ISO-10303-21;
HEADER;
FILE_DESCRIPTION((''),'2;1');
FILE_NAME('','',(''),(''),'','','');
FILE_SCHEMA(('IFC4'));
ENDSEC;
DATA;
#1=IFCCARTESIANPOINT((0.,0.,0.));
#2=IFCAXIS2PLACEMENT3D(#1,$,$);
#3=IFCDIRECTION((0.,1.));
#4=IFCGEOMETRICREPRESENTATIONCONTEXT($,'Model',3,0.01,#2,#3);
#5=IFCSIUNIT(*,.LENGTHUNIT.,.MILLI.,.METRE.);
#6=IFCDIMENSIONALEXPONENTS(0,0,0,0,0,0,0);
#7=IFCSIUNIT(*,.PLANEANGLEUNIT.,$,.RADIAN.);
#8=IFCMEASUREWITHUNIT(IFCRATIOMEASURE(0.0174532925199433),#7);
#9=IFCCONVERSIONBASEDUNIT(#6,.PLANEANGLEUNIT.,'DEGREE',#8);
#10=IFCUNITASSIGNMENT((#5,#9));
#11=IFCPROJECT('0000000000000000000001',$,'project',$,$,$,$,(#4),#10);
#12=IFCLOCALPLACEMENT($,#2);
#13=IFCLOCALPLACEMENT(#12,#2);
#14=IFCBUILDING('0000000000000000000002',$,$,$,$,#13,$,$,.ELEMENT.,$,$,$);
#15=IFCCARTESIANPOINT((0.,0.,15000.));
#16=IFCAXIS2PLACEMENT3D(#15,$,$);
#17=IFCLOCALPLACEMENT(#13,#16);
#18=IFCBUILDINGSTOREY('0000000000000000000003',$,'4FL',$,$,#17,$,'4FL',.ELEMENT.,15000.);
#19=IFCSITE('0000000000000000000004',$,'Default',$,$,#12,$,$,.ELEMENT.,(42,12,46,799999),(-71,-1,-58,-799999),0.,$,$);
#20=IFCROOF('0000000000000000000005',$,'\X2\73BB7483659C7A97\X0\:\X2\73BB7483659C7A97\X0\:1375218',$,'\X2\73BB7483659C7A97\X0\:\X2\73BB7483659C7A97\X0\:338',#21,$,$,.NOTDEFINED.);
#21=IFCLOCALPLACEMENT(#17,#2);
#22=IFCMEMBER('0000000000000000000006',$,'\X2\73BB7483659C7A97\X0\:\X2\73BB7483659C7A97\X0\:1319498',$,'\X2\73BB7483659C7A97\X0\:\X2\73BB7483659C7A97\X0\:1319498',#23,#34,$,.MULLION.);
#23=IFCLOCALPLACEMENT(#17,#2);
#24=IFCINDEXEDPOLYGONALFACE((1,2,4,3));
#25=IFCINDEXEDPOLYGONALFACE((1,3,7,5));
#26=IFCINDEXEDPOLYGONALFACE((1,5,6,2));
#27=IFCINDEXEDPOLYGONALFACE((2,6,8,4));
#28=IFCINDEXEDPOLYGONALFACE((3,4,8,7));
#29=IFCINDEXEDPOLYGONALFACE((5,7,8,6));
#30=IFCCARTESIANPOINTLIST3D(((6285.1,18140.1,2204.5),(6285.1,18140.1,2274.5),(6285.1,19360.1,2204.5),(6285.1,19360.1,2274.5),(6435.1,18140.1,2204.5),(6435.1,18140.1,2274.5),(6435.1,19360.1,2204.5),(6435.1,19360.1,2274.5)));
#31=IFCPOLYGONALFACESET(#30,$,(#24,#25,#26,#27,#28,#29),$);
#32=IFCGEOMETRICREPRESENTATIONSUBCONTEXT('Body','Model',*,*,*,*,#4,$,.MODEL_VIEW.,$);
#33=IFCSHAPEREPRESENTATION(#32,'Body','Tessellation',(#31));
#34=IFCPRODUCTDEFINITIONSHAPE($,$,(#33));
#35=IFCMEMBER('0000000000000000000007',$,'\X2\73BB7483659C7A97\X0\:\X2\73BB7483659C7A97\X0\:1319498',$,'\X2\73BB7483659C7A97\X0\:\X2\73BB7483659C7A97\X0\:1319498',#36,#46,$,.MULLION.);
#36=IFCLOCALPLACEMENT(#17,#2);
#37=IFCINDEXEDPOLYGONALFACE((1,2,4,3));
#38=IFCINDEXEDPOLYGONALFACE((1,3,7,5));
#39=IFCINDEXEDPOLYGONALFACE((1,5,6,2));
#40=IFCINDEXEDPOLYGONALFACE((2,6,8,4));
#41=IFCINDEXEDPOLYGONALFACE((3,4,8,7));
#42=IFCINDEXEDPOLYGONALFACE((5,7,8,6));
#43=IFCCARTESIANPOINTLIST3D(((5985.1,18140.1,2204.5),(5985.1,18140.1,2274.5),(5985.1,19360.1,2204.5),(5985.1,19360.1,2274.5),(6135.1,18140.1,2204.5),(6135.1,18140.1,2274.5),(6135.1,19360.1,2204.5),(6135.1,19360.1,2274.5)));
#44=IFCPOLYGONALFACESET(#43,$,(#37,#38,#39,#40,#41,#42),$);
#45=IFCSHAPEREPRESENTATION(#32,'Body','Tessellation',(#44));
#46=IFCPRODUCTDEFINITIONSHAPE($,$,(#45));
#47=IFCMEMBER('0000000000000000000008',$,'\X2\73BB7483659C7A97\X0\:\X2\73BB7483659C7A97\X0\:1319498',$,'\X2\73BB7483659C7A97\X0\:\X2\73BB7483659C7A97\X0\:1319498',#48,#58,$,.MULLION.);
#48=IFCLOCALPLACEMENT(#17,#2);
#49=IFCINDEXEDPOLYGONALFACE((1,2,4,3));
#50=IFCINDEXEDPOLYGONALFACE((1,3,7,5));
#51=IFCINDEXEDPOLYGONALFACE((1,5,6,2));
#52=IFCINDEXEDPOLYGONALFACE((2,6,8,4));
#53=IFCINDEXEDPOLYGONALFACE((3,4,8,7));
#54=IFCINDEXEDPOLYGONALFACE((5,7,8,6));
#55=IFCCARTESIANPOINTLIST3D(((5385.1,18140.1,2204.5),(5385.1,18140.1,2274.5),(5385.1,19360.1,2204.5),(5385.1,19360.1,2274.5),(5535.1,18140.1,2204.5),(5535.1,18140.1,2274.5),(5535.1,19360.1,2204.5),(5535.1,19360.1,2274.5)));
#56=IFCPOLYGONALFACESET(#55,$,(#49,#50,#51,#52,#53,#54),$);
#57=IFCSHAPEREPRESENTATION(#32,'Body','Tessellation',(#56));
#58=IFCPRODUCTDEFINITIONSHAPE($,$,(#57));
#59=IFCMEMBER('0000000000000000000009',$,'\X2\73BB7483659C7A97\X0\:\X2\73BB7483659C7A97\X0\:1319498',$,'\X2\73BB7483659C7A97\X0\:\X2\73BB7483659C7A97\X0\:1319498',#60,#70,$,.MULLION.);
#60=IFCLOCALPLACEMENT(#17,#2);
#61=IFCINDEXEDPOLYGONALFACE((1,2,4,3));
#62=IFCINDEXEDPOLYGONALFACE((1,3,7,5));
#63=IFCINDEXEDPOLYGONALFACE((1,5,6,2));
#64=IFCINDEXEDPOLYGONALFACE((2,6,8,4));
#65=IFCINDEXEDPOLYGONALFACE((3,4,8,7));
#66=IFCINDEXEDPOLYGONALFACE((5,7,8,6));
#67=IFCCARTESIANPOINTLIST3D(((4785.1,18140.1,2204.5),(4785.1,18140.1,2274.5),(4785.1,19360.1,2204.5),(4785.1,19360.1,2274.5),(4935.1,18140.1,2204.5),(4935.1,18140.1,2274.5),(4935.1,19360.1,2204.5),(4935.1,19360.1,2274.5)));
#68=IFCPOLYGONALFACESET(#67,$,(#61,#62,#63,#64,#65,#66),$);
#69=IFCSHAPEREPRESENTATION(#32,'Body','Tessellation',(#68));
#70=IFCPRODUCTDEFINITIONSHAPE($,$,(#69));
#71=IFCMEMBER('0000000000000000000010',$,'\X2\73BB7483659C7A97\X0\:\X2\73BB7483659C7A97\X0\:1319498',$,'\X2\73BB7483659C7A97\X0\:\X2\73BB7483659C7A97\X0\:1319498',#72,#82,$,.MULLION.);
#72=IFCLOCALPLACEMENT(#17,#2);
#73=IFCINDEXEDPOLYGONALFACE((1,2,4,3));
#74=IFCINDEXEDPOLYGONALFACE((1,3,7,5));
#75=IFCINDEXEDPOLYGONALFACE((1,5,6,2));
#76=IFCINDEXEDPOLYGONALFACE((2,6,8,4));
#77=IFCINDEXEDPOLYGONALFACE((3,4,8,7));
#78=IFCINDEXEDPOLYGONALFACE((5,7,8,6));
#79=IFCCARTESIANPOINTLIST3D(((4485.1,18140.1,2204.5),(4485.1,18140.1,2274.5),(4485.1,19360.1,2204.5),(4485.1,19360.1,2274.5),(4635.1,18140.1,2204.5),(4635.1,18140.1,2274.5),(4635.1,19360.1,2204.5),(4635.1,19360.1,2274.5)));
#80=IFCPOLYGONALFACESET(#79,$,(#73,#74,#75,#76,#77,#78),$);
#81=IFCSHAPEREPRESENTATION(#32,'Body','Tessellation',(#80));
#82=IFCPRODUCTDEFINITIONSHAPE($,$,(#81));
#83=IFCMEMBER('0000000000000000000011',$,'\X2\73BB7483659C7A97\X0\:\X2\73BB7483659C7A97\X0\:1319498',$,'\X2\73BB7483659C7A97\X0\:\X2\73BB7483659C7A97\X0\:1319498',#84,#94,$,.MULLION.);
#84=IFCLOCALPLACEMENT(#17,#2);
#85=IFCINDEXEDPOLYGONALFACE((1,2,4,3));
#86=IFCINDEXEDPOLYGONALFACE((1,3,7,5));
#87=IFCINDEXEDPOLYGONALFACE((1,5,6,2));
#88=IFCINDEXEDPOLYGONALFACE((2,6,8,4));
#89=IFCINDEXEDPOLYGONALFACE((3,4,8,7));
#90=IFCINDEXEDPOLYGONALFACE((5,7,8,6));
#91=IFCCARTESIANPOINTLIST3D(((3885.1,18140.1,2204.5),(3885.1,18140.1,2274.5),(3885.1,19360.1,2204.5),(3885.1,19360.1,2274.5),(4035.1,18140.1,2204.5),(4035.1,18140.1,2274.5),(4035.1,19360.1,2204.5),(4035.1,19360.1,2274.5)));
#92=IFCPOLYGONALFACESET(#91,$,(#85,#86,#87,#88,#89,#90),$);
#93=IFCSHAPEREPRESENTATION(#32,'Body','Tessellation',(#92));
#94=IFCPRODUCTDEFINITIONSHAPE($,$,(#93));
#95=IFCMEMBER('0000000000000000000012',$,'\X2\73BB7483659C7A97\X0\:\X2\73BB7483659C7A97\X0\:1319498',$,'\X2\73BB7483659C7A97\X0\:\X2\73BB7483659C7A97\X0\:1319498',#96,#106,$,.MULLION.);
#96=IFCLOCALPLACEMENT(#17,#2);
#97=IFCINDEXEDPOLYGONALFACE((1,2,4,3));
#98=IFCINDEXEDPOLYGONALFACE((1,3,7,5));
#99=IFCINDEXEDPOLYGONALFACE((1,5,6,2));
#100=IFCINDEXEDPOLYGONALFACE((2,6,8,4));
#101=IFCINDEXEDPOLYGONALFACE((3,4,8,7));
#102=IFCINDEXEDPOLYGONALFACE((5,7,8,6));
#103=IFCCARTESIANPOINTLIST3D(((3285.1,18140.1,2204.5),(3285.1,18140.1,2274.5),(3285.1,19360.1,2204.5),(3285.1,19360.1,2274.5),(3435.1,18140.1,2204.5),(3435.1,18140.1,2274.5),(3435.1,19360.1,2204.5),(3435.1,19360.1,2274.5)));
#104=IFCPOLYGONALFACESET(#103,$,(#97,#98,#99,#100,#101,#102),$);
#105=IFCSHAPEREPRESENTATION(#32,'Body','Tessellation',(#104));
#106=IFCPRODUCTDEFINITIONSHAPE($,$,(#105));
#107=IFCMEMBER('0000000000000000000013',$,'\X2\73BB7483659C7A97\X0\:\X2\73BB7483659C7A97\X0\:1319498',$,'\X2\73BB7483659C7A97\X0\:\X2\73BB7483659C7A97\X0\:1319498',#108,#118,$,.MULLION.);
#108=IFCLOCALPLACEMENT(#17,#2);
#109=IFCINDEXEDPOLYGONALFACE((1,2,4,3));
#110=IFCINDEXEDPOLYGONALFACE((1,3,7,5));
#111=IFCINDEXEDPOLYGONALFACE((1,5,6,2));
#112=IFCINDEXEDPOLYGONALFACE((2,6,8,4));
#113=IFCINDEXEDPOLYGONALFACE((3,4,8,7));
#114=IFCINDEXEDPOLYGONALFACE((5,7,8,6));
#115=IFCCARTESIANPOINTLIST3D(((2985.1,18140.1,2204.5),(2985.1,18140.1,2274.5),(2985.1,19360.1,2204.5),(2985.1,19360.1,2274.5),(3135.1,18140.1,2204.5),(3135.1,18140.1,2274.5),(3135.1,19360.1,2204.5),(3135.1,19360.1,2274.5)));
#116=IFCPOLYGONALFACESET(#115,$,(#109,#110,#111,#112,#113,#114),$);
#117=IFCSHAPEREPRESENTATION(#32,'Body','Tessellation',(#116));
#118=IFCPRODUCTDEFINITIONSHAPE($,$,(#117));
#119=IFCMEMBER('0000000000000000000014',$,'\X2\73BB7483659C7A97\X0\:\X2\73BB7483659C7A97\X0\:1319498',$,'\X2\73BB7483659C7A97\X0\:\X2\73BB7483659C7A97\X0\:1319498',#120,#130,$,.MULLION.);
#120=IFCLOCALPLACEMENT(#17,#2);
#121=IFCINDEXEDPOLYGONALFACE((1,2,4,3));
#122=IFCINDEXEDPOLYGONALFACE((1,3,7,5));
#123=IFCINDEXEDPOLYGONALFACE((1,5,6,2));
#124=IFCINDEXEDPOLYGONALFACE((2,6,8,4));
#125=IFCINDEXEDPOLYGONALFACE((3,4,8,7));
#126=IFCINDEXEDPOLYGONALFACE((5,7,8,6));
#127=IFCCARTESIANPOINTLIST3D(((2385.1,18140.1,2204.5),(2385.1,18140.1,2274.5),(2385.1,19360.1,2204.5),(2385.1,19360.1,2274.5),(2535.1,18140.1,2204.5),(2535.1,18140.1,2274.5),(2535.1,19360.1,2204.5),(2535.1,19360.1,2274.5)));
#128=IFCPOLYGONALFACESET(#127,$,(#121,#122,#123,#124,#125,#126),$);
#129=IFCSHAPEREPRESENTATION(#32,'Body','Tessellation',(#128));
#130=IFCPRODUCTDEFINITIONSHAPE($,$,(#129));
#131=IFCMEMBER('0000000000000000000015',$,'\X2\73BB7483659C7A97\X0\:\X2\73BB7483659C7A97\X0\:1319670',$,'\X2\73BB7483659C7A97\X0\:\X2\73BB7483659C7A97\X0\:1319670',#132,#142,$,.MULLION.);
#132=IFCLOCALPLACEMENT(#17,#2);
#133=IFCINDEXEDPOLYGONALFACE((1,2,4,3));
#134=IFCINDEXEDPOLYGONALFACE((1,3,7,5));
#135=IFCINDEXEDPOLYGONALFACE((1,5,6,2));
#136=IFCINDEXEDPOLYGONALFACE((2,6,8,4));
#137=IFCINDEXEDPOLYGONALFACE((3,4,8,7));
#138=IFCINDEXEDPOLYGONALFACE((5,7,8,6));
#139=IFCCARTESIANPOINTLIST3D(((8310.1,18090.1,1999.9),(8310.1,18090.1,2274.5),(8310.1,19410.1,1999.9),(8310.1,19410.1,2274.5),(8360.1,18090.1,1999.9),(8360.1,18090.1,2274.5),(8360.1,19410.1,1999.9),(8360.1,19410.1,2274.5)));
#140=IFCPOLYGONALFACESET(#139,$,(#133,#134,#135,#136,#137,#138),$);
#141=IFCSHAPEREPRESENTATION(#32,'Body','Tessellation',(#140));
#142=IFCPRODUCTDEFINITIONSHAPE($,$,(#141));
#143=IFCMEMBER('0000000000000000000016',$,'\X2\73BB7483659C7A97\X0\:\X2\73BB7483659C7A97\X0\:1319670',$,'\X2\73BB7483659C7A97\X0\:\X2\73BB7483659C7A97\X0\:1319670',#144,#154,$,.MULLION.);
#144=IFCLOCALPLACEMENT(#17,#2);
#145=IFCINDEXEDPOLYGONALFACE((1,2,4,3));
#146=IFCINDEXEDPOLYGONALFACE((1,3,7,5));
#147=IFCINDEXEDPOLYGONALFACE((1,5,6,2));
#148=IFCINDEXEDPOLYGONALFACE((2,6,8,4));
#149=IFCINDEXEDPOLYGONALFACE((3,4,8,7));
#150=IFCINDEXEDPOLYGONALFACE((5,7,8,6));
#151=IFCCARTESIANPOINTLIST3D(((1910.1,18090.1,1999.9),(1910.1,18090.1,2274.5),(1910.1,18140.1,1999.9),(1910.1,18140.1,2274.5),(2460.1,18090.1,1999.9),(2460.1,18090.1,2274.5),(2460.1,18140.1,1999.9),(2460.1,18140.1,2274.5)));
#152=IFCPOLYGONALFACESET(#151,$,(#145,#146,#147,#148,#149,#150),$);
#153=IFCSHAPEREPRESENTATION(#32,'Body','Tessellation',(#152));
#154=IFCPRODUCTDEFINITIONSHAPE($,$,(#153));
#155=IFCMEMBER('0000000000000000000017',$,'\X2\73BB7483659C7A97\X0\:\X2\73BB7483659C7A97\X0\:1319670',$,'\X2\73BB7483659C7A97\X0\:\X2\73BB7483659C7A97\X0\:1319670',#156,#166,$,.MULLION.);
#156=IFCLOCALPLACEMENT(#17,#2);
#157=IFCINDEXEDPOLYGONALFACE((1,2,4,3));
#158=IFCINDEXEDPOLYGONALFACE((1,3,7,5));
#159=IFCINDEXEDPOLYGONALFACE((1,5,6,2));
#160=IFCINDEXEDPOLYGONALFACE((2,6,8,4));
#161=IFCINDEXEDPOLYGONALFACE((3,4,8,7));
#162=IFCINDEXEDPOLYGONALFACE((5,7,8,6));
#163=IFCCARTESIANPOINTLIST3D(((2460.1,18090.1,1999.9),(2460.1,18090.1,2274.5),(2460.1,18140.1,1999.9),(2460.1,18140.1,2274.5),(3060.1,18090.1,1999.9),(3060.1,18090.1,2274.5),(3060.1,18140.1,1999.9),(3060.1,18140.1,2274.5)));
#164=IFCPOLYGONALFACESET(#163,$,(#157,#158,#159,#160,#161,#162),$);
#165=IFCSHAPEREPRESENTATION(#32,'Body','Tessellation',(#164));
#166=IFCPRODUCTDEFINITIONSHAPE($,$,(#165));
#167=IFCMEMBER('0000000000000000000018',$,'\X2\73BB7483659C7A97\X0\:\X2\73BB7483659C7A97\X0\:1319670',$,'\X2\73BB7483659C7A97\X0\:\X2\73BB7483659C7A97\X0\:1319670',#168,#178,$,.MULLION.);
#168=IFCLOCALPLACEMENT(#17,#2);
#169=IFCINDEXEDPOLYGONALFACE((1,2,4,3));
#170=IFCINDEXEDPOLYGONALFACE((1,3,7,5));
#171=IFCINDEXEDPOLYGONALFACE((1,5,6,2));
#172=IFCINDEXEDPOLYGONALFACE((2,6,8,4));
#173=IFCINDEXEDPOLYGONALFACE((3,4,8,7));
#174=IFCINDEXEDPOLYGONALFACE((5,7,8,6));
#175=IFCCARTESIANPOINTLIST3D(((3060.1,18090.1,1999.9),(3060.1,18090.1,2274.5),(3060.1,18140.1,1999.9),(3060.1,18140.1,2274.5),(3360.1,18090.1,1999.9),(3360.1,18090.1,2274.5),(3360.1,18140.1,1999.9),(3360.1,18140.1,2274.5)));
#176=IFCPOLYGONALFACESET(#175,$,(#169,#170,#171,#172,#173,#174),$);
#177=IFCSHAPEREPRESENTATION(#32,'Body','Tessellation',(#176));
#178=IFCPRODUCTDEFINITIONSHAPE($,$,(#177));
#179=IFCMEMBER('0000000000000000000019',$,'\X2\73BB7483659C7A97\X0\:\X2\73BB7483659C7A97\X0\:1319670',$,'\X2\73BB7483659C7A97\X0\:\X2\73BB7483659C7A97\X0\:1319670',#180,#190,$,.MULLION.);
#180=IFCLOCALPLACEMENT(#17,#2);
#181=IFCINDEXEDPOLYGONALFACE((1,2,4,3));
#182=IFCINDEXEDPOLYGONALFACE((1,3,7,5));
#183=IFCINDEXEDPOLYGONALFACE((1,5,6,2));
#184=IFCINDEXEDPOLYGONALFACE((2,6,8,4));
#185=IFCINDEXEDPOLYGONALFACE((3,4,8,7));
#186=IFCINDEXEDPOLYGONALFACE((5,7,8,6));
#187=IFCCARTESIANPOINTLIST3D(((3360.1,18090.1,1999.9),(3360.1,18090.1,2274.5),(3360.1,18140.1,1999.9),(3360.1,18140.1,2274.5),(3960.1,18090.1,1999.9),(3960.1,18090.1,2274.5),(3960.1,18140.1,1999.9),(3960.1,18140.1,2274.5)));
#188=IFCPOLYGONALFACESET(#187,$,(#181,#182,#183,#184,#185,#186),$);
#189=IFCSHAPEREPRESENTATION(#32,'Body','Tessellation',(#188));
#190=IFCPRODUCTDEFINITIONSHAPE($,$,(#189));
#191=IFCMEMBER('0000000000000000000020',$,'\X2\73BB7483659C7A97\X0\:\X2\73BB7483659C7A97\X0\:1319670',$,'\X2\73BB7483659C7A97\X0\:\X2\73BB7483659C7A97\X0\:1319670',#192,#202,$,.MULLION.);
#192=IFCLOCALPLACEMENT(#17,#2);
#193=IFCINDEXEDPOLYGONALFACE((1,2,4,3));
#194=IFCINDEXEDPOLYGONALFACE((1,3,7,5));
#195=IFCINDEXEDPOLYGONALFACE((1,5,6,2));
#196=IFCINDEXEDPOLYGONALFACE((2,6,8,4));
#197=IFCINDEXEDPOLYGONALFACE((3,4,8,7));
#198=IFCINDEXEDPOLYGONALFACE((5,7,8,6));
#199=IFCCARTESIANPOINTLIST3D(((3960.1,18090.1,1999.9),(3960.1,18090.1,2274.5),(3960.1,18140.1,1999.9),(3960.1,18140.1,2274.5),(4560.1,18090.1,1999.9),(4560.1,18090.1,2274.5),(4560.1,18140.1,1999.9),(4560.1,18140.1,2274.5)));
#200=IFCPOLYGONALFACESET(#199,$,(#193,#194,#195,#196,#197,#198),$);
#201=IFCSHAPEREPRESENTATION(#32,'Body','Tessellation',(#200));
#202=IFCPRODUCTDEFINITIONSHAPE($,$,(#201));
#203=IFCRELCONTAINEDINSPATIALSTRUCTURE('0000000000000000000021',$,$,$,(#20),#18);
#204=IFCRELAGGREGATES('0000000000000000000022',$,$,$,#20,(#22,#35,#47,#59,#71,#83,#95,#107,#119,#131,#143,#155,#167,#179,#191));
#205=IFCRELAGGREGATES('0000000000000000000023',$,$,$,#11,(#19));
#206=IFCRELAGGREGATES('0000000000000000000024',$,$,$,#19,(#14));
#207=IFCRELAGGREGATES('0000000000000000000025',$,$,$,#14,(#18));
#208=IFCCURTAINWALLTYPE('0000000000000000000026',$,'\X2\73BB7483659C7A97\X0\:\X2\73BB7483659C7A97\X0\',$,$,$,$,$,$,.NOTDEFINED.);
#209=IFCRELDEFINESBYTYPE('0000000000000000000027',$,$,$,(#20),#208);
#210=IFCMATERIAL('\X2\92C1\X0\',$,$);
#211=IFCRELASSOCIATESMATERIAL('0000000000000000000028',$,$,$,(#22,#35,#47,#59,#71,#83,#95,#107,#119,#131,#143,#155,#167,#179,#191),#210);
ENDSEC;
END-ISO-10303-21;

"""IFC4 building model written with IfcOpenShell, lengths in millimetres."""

from ifc_helpers import new_model, entity, si_unit, converted_unit, direction, frame, frame_2d, origin, place, context, subcontext, project, spatial, rectangle, extrude, material, type_object, element, aggregate, save


model = new_model("IFC4")

# Units and contexts
model_context = context("Model", 3, precision=0.01, world=origin(), true_north=direction((0.0, 1.0)))
body_context = subcontext(model_context, "Body", "Model", "MODEL_VIEW")
ifc_project = project(units=[si_unit("LENGTHUNIT", "METRE", prefix="MILLI"), converted_unit("PLANEANGLEUNIT", "DEGREE", entity("IfcRatioMeasure", 0.0174532925199433), si_unit("PLANEANGLEUNIT", "RADIAN"), dimensions=[0, 0, 0, 0, 0, 0, 0])], contexts=[model_context])

# Site, building, storey
site_placement = place(None, origin())
site = spatial("IfcSite", under=ifc_project, at=site_placement, Name="Default", CompositionType="ELEMENT", RefLatitude=(42, 12, 46, 799999), RefLongitude=(-71, -1, -58, -799999), RefElevation=0.0)
building_placement = place(site_placement, origin())
building = spatial("IfcBuilding", under=site, at=building_placement, CompositionType="ELEMENT")
storey_placement = place(building_placement, frame((0.0, 0.0, 15000.0)))
storey = spatial("IfcBuildingStorey", under=building, at=storey_placement, Name="4FL", LongName="4FL", CompositionType="ELEMENT", Elevation=15000.0)

# Roof, members
curtain_wall_type = type_object("IfcCurtainWallType", Name="玻璃斜窗:玻璃斜窗", PredefinedType="NOTDEFINED")
roof_placement = place(storey_placement, frame((0.0, 0.0, -15000.0)))
roof = element("IfcRoof", 1, at=roof_placement, inside=storey, type_object=curtain_wall_type, Name="玻璃斜窗:玻璃斜窗:1375218", ObjectType="玻璃斜窗:玻璃斜窗:338", PredefinedType="NOTDEFINED")
ifc_material_1 = material(Name="鋁")
member_1_placement = place(roof_placement, frame((0.0, 0.0, 15000.0)))
member_1 = element("IfcMember", 2, at=member_1_placement, material=ifc_material_1, Name="玻璃斜窗:玻璃斜窗:1319498", ObjectType="玻璃斜窗:玻璃斜窗:1319498", PredefinedType="MULLION", context=body_context, shape_type="SweptSolid", body=[
    extrude(rectangle(XDim=70.0, YDim=150.0, at=frame_2d((0.0, 0.0), x_axis=(1.0, 0.0))), frame((6360.1, 19360.1, 2239.5), z_axis=(0.0, -1.0, 0.0), x_axis=(0.0, 0.0, -1.0)), (0.0, 0.0, 1.0), 1220.0),
])
member_2_placement = place(roof_placement, frame((0.0, 0.0, 15000.0)))
member_2 = element("IfcMember", 3, at=member_2_placement, material=ifc_material_1, Name="玻璃斜窗:玻璃斜窗:1319498", ObjectType="玻璃斜窗:玻璃斜窗:1319498", PredefinedType="MULLION", context=body_context, shape_type="SweptSolid", body=[
    extrude(rectangle(XDim=70.0, YDim=150.0, at=frame_2d((0.0, 0.0), x_axis=(1.0, 0.0))), frame((6060.1, 19360.1, 2239.5), z_axis=(0.0, -1.0, 0.0), x_axis=(0.0, 0.0, -1.0)), (0.0, 0.0, 1.0), 1220.0),
])
member_3_placement = place(roof_placement, frame((0.0, 0.0, 15000.0)))
member_3 = element("IfcMember", 4, at=member_3_placement, material=ifc_material_1, Name="玻璃斜窗:玻璃斜窗:1319498", ObjectType="玻璃斜窗:玻璃斜窗:1319498", PredefinedType="MULLION", context=body_context, shape_type="SweptSolid", body=[
    extrude(rectangle(XDim=70.0, YDim=150.0, at=frame_2d((0.0, 0.0), x_axis=(1.0, 0.0))), frame((5460.1, 19360.1, 2239.5), z_axis=(0.0, -1.0, 0.0), x_axis=(0.0, 0.0, -1.0)), (0.0, 0.0, 1.0), 1220.0),
])
member_4_placement = place(roof_placement, frame((0.0, 0.0, 15000.0)))
member_4 = element("IfcMember", 5, at=member_4_placement, material=ifc_material_1, Name="玻璃斜窗:玻璃斜窗:1319498", ObjectType="玻璃斜窗:玻璃斜窗:1319498", PredefinedType="MULLION", context=body_context, shape_type="SweptSolid", body=[
    extrude(rectangle(XDim=70.0, YDim=150.0, at=frame_2d((0.0, 0.0), x_axis=(1.0, 0.0))), frame((4860.1, 19360.1, 2239.5), z_axis=(0.0, -1.0, 0.0), x_axis=(0.0, 0.0, -1.0)), (0.0, 0.0, 1.0), 1220.0),
])
member_5_placement = place(roof_placement, frame((0.0, 0.0, 15000.0)))
member_5 = element("IfcMember", 6, at=member_5_placement, material=ifc_material_1, Name="玻璃斜窗:玻璃斜窗:1319498", ObjectType="玻璃斜窗:玻璃斜窗:1319498", PredefinedType="MULLION", context=body_context, shape_type="SweptSolid", body=[
    extrude(rectangle(XDim=70.0, YDim=150.0, at=frame_2d((0.0, 0.0), x_axis=(1.0, 0.0))), frame((4560.1, 19360.1, 2239.5), z_axis=(0.0, -1.0, 0.0), x_axis=(0.0, 0.0, -1.0)), (0.0, 0.0, 1.0), 1220.0),
])
member_6_placement = place(roof_placement, frame((0.0, 0.0, 15000.0)))
member_6 = element("IfcMember", 7, at=member_6_placement, material=ifc_material_1, Name="玻璃斜窗:玻璃斜窗:1319498", ObjectType="玻璃斜窗:玻璃斜窗:1319498", PredefinedType="MULLION", context=body_context, shape_type="SweptSolid", body=[
    extrude(rectangle(XDim=70.0, YDim=150.0, at=frame_2d((0.0, 0.0), x_axis=(1.0, 0.0))), frame((3960.1, 19360.1, 2239.5), z_axis=(0.0, -1.0, 0.0), x_axis=(0.0, 0.0, -1.0)), (0.0, 0.0, 1.0), 1220.0),
])
member_7_placement = place(roof_placement, frame((0.0, 0.0, 15000.0)))
member_7 = element("IfcMember", 8, at=member_7_placement, material=ifc_material_1, Name="玻璃斜窗:玻璃斜窗:1319498", ObjectType="玻璃斜窗:玻璃斜窗:1319498", PredefinedType="MULLION", context=body_context, shape_type="SweptSolid", body=[
    extrude(rectangle(XDim=70.0, YDim=150.0, at=frame_2d((0.0, 0.0), x_axis=(1.0, 0.0))), frame((3360.1, 19360.1, 2239.5), z_axis=(0.0, -1.0, 0.0), x_axis=(0.0, 0.0, -1.0)), (0.0, 0.0, 1.0), 1220.0),
])
member_8_placement = place(roof_placement, frame((0.0, 0.0, 15000.0)))
member_8 = element("IfcMember", 9, at=member_8_placement, material=ifc_material_1, Name="玻璃斜窗:玻璃斜窗:1319498", ObjectType="玻璃斜窗:玻璃斜窗:1319498", PredefinedType="MULLION", context=body_context, shape_type="SweptSolid", body=[
    extrude(rectangle(XDim=70.0, YDim=150.0, at=frame_2d((0.0, 0.0), x_axis=(1.0, 0.0))), frame((3060.1, 19360.1, 2239.5), z_axis=(0.0, -1.0, 0.0), x_axis=(0.0, 0.0, -1.0)), (0.0, 0.0, 1.0), 1220.0),
])
member_9_placement = place(roof_placement, frame((0.0, 0.0, 15000.0)))
member_9 = element("IfcMember", 10, at=member_9_placement, material=ifc_material_1, Name="玻璃斜窗:玻璃斜窗:1319498", ObjectType="玻璃斜窗:玻璃斜窗:1319498", PredefinedType="MULLION", context=body_context, shape_type="SweptSolid", body=[
    extrude(rectangle(XDim=70.0, YDim=150.0, at=frame_2d((0.0, 0.0), x_axis=(1.0, 0.0))), frame((2460.1, 19360.1, 2239.5), z_axis=(0.0, -1.0, 0.0), x_axis=(0.0, 0.0, -1.0)), (0.0, 0.0, 1.0), 1220.0),
])
member_10_placement = place(roof_placement, frame((0.0, 0.0, 15000.0)))
member_10 = element("IfcMember", 11, at=member_10_placement, material=ifc_material_1, Name="玻璃斜窗:玻璃斜窗:1319670", ObjectType="玻璃斜窗:玻璃斜窗:1319670", PredefinedType="MULLION", context=body_context, shape_type="SweptSolid", body=[
    extrude(rectangle(XDim=274.5, YDim=50.0, at=frame_2d((0.0, 0.0), x_axis=(1.0, 0.0))), frame((8335.1, 19410.1, 2137.2), z_axis=(0.0, -1.0, 0.0), x_axis=(0.0, 0.0, -1.0)), (0.0, 0.0, 1.0), 1320.0),
])
member_11_placement = place(roof_placement, frame((0.0, 0.0, 15000.0)))
member_11 = element("IfcMember", 12, at=member_11_placement, material=ifc_material_1, Name="玻璃斜窗:玻璃斜窗:1319670", ObjectType="玻璃斜窗:玻璃斜窗:1319670", PredefinedType="MULLION", context=body_context, shape_type="SweptSolid", body=[
    extrude(rectangle(XDim=274.5, YDim=50.0, at=frame_2d((0.0, 0.0), x_axis=(1.0, 0.0))), frame((2460.1, 18115.1, 2137.2), z_axis=(-1.0, 0.0, 0.0), x_axis=(0.0, 0.0, -1.0)), (0.0, 0.0, 1.0), 550.0),
])
member_12_placement = place(roof_placement, frame((0.0, 0.0, 15000.0)))
member_12 = element("IfcMember", 13, at=member_12_placement, material=ifc_material_1, Name="玻璃斜窗:玻璃斜窗:1319670", ObjectType="玻璃斜窗:玻璃斜窗:1319670", PredefinedType="MULLION", context=body_context, shape_type="SweptSolid", body=[
    extrude(rectangle(XDim=274.5, YDim=50.0, at=frame_2d((0.0, 0.0), x_axis=(1.0, 0.0))), frame((3060.1, 18115.1, 2137.2), z_axis=(-1.0, 0.0, 0.0), x_axis=(0.0, 0.0, -1.0)), (0.0, 0.0, 1.0), 600.0),
])
member_13_placement = place(roof_placement, frame((0.0, 0.0, 15000.0)))
member_13 = element("IfcMember", 14, at=member_13_placement, material=ifc_material_1, Name="玻璃斜窗:玻璃斜窗:1319670", ObjectType="玻璃斜窗:玻璃斜窗:1319670", PredefinedType="MULLION", context=body_context, shape_type="SweptSolid", body=[
    extrude(rectangle(XDim=274.5, YDim=50.0, at=frame_2d((0.0, 0.0), x_axis=(1.0, 0.0))), frame((3360.1, 18115.1, 2137.2), z_axis=(-1.0, 0.0, 0.0), x_axis=(0.0, 0.0, -1.0)), (0.0, 0.0, 1.0), 300.0),
])
member_14_placement = place(roof_placement, frame((0.0, 0.0, 15000.0)))
member_14 = element("IfcMember", 15, at=member_14_placement, material=ifc_material_1, Name="玻璃斜窗:玻璃斜窗:1319670", ObjectType="玻璃斜窗:玻璃斜窗:1319670", PredefinedType="MULLION", context=body_context, shape_type="SweptSolid", body=[
    extrude(rectangle(XDim=274.5, YDim=50.0, at=frame_2d((0.0, 0.0), x_axis=(1.0, 0.0))), frame((3960.1, 18115.1, 2137.2), z_axis=(-1.0, 0.0, 0.0), x_axis=(0.0, 0.0, -1.0)), (0.0, 0.0, 1.0), 600.0),
])
member_15_placement = place(roof_placement, frame((0.0, 0.0, 15000.0)))
member_15 = element("IfcMember", 16, at=member_15_placement, material=ifc_material_1, Name="玻璃斜窗:玻璃斜窗:1319670", ObjectType="玻璃斜窗:玻璃斜窗:1319670", PredefinedType="MULLION", context=body_context, shape_type="SweptSolid", body=[
    extrude(rectangle(XDim=274.5, YDim=50.0, at=frame_2d((0.0, 0.0), x_axis=(1.0, 0.0))), frame((4560.1, 18115.1, 2137.2), z_axis=(-1.0, 0.0, 0.0), x_axis=(0.0, 0.0, -1.0)), (0.0, 0.0, 1.0), 600.0),
])
aggregate(roof, [member_1, member_2, member_3, member_4, member_5, member_6, member_7, member_8, member_9, member_10, member_11, member_12, member_13, member_14, member_15])

save(model, "model.ifc")
